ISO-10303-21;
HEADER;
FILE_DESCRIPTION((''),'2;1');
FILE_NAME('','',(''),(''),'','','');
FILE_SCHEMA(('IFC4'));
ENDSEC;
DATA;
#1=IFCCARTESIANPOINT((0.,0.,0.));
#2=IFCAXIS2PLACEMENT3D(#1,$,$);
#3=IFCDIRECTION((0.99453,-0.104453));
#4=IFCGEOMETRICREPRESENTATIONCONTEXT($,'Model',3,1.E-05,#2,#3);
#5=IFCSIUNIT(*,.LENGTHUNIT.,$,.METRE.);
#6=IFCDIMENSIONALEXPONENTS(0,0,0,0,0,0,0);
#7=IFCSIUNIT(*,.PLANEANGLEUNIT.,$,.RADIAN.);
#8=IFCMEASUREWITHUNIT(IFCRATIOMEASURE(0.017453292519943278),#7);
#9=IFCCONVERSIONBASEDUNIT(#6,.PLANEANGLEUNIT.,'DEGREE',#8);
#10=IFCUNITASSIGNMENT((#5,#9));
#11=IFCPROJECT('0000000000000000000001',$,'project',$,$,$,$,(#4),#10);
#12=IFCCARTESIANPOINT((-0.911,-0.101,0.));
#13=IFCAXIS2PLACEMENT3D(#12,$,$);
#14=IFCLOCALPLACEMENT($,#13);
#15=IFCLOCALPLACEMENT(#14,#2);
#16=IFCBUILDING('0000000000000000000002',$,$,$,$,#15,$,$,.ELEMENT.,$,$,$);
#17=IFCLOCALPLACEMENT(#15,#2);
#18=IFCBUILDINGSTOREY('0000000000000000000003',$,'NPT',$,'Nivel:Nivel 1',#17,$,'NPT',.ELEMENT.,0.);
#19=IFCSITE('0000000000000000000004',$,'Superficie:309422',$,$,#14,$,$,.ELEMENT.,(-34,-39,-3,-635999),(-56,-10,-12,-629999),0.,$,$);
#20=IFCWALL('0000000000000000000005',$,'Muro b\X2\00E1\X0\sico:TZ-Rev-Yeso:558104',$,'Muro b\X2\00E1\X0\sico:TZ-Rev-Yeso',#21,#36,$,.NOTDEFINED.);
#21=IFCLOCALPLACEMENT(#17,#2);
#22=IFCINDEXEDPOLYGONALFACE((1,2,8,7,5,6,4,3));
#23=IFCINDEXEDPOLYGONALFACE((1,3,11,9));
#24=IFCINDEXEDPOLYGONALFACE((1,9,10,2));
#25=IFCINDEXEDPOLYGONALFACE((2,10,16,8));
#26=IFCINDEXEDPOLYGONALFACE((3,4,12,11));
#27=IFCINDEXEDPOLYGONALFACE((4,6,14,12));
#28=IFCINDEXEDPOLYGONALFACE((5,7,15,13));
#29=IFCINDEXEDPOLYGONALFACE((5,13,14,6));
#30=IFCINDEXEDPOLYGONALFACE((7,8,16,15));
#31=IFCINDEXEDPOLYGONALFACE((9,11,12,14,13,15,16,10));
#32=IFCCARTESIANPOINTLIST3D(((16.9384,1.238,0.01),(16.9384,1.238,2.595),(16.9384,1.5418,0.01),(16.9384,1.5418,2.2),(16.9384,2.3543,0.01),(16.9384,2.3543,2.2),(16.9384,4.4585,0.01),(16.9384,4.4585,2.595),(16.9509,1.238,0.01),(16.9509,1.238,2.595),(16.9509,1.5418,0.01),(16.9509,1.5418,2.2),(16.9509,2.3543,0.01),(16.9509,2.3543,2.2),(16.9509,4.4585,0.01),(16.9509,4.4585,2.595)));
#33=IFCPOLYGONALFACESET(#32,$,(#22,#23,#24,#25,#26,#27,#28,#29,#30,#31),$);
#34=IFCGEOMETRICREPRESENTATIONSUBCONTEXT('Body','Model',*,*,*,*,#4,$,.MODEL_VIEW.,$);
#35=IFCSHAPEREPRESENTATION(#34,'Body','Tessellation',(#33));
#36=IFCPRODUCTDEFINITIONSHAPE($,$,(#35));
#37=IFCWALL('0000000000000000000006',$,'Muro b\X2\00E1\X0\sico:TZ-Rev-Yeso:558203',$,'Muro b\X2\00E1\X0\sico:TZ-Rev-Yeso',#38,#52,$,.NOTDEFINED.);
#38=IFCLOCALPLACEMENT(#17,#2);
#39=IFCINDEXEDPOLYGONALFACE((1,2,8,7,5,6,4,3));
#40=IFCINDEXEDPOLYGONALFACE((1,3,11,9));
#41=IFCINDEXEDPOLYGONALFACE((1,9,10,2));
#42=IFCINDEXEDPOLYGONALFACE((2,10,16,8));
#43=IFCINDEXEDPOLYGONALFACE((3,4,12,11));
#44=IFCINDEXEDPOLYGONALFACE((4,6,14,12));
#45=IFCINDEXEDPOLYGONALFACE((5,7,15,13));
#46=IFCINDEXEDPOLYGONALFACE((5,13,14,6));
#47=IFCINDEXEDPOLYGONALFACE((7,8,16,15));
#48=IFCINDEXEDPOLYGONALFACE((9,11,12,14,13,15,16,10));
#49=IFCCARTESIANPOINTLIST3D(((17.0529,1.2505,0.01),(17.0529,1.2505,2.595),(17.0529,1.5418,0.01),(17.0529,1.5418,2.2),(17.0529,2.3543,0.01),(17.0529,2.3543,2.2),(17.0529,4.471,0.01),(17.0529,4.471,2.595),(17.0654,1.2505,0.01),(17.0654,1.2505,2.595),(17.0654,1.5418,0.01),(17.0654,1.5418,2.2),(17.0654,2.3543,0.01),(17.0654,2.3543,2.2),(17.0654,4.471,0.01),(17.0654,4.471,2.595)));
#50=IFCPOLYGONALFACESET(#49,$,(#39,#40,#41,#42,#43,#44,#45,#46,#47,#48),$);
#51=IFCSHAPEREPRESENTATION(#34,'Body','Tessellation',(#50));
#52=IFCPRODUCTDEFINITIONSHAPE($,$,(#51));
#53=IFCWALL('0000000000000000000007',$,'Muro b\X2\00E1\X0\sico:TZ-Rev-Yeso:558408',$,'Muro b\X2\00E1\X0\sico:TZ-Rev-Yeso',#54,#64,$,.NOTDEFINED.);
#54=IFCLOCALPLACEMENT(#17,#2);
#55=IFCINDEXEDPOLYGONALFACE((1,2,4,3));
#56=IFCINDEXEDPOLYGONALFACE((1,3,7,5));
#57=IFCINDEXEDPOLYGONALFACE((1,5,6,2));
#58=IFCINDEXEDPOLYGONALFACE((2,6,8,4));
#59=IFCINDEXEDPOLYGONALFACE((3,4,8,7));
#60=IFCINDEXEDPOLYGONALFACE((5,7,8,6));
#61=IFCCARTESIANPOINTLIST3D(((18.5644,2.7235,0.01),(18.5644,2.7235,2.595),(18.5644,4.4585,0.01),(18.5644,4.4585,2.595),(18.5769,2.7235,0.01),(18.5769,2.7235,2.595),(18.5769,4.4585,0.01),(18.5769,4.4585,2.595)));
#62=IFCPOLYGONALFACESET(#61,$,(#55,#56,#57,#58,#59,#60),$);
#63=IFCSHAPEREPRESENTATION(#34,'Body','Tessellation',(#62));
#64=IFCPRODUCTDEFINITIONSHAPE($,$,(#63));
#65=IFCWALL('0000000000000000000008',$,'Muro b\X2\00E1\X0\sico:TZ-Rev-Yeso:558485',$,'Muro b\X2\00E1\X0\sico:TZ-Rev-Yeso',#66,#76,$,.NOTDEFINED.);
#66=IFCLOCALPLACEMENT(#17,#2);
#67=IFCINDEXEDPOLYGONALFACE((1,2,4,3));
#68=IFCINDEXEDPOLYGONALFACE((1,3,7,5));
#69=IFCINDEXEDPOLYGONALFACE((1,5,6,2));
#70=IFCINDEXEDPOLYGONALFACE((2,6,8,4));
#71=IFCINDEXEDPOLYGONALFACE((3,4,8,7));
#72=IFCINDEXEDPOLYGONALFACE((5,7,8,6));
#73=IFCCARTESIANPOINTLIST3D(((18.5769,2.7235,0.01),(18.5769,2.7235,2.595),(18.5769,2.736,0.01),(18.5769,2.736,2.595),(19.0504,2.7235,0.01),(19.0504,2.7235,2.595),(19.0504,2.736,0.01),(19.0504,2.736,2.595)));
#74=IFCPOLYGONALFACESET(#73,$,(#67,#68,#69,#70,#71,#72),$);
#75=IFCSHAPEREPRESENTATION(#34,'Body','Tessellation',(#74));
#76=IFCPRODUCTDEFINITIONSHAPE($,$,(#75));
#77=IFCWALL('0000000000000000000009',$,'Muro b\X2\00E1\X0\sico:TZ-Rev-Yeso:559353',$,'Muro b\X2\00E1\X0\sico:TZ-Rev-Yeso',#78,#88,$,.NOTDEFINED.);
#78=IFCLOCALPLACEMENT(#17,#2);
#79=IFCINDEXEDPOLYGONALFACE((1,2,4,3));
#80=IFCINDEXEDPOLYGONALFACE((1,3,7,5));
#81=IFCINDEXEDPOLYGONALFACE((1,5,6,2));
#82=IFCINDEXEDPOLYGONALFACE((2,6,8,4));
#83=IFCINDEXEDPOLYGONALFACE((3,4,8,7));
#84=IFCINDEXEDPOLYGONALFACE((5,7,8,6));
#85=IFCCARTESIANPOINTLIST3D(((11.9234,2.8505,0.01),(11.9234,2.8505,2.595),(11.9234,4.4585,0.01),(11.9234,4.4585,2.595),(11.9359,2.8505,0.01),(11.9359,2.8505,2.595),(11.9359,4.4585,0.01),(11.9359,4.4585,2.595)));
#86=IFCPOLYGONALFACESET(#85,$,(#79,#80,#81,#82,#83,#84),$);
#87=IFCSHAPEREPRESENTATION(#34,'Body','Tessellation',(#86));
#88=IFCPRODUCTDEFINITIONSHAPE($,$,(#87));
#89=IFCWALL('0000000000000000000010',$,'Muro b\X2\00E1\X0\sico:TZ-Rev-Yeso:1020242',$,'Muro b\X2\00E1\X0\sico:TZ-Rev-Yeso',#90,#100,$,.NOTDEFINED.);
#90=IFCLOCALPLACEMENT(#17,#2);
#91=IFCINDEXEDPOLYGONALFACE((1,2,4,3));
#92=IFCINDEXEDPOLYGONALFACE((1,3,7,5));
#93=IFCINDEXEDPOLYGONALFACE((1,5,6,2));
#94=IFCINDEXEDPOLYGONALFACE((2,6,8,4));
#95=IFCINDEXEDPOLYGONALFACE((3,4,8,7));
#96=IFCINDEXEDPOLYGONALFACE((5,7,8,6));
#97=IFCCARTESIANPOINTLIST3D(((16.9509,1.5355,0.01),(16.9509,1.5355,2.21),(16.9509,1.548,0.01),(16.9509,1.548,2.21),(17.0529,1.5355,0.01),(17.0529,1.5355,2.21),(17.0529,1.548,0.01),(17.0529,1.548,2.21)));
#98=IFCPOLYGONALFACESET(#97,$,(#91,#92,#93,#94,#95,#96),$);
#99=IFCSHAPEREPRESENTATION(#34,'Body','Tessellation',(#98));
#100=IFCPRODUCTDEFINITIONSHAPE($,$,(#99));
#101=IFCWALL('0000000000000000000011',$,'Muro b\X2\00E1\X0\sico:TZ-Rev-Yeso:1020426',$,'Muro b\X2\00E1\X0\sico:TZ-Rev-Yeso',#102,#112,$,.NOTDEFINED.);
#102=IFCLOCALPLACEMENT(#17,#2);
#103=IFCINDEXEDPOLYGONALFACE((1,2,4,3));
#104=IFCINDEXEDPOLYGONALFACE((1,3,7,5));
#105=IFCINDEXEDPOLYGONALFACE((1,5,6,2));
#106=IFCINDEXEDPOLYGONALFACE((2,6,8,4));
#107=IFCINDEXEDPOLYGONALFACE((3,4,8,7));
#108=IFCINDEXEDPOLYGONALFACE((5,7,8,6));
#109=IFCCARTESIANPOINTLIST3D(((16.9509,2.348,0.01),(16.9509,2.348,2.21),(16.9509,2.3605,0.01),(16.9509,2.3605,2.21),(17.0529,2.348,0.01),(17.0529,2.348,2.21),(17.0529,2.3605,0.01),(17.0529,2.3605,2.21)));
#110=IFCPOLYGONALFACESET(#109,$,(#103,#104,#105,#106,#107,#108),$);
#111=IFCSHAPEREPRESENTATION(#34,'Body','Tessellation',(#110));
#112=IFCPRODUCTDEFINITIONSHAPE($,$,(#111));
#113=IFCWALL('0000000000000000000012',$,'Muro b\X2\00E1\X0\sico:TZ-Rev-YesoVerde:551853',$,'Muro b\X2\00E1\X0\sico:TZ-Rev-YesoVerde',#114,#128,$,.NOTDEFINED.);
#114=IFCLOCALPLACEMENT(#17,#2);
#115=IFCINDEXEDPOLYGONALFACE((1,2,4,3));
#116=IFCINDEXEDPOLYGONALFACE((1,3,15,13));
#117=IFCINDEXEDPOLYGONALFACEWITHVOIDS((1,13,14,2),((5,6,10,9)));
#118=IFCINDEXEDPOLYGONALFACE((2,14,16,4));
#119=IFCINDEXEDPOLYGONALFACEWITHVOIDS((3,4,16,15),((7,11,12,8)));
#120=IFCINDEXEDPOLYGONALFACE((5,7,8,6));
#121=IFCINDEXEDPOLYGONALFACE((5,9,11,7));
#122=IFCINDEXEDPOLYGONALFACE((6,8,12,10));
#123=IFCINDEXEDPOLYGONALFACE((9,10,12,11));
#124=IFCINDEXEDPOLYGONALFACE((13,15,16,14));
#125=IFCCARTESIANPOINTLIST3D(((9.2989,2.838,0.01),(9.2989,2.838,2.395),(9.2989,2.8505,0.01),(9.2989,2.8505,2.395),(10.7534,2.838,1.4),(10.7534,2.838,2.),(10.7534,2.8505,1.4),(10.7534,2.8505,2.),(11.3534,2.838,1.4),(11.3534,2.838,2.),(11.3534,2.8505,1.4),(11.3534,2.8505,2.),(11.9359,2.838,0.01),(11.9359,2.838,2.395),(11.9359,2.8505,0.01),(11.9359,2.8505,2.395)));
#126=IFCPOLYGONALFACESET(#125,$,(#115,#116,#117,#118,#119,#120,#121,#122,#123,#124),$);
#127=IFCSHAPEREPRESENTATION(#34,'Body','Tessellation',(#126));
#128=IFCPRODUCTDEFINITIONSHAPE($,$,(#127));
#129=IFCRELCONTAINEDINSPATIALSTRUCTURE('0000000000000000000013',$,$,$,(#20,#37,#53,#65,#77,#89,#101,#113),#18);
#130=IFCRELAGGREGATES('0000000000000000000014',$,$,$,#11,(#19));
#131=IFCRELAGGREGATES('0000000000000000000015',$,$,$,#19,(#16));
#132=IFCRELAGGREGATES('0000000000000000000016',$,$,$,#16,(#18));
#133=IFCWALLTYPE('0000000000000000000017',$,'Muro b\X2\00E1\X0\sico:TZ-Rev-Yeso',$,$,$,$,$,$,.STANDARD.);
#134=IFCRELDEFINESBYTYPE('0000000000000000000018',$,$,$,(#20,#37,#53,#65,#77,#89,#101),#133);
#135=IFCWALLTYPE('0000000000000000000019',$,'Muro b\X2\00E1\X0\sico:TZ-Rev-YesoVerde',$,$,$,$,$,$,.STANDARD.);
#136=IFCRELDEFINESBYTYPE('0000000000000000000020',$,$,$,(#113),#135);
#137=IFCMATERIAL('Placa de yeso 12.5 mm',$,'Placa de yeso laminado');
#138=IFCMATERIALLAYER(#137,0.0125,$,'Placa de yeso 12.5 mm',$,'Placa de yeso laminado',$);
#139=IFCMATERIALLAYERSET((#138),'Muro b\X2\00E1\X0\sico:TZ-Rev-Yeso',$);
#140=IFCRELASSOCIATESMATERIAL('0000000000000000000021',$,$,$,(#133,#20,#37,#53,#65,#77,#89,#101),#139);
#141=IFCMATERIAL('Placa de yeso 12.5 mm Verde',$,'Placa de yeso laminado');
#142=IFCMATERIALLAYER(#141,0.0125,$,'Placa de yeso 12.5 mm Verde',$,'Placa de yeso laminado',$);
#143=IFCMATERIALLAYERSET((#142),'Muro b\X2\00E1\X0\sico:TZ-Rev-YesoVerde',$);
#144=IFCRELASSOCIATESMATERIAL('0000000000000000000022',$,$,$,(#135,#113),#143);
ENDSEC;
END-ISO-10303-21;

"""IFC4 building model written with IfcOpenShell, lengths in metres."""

from ifc_helpers import new_model, entity, si_unit, converted_unit, direction, frame, frame_2d, origin, place, context, subcontext, project, spatial, rectangle, extrude, material, layer, layer_set, layer_usage, type_object, element, save


model = new_model("IFC4")

# Units and contexts
model_context = context("Model", 3, precision=1e-05, world=origin(), true_north=direction((0.99453, -0.104453)))
body_context = subcontext(model_context, "Body", "Model", "MODEL_VIEW")
ifc_project = project(units=[si_unit("LENGTHUNIT", "METRE"), converted_unit("PLANEANGLEUNIT", "DEGREE", entity("IfcRatioMeasure", 0.017453292519943278), si_unit("PLANEANGLEUNIT", "RADIAN"), dimensions=[0, 0, 0, 0, 0, 0, 0])], contexts=[model_context])

# Site, building, storey
site_placement = place(None, frame((-0.911, -0.101, 0.0)))
site = spatial("IfcSite", under=ifc_project, at=site_placement, Name="Superficie:309422", CompositionType="ELEMENT", RefLatitude=(-34, -39, -3, -635999), RefLongitude=(-56, -10, -12, -629999), RefElevation=0.0)
building_placement = place(site_placement, origin())
building = spatial("IfcBuilding", under=site, at=building_placement, CompositionType="ELEMENT")
storey_placement = place(building_placement, origin())
storey = spatial("IfcBuildingStorey", under=building, at=storey_placement, Name="NPT", ObjectType="Nivel:Nivel 1", LongName="NPT", CompositionType="ELEMENT", Elevation=0.0)

# Shared definitions
ifc_material_1 = material(Name="Placa de yeso 12.5 mm", Category="Placa de yeso laminado")
ifc_layer_1 = layer(ifc_material_1, 0.0125, Name="Placa de yeso 12.5 mm", Category="Placa de yeso laminado")
ifc_layer_set_1 = layer_set([ifc_layer_1], Name="Muro básico:TZ-Rev-Yeso")
wall_type_1 = type_object("IfcWallType", Name="Muro básico:TZ-Rev-Yeso", PredefinedType="STANDARD", material=ifc_layer_set_1)

# Walls, openings
ifc_layer_usage_1 = layer_usage(ifc_layer_set_1, "AXIS2", "NEGATIVE", 0.0063)
wall_1_placement = place(storey_placement, frame((16.9447, 4.4585, 0.01), z_axis=(0.0, 0.0, 1.0), x_axis=(0.0, -1.0, 0.0)))
wall_1 = element("IfcWall", 1, at=wall_1_placement, inside=storey, type_object=wall_type_1, material=ifc_layer_usage_1, Name="Muro básico:TZ-Rev-Yeso:558104", ObjectType="Muro básico:TZ-Rev-Yeso", PredefinedType="NOTDEFINED", context=body_context, shape_type="SweptSolid", body=[
    extrude(rectangle(XDim=3.2205, YDim=0.0125, at=frame_2d((1.6102, 0.0), x_axis=(-1.0, 0.0))), origin(), (0.0, 0.0, 1.0), 2.585),
])
opening_1_placement = place(wall_1_placement, origin())
element("IfcOpeningElement", 2, at=opening_1_placement, cuts=wall_1, PredefinedType="OPENING", context=body_context, shape_type="SweptSolid", body=[
    extrude(rectangle(XDim=2.19, YDim=0.8125, at=frame_2d((0.0, 0.0), x_axis=(1.0, 0.0))), frame((2.5105, 0.0063, 1.095), z_axis=(0.0, -1.0, 0.0), x_axis=(0.0, 0.0, 1.0)), (0.0, 0.0, 1.0), 0.0125),
])
ifc_layer_usage_2 = layer_usage(ifc_layer_set_1, "AXIS2", "NEGATIVE", 0.0063)
wall_2_placement = place(storey_placement, frame((17.0592, 1.2505, 0.01), z_axis=(0.0, 0.0, 1.0), x_axis=(0.0, 1.0, 0.0)))
wall_2 = element("IfcWall", 3, at=wall_2_placement, inside=storey, type_object=wall_type_1, material=ifc_layer_usage_2, Name="Muro básico:TZ-Rev-Yeso:558203", ObjectType="Muro básico:TZ-Rev-Yeso", PredefinedType="NOTDEFINED", context=body_context, shape_type="SweptSolid", body=[
    extrude(rectangle(XDim=3.2205, YDim=0.0125, at=frame_2d((1.6102, 0.0), x_axis=(-1.0, 0.0))), origin(), (0.0, 0.0, 1.0), 2.585),
])
opening_2_placement = place(wall_2_placement, origin())
element("IfcOpeningElement", 4, at=opening_2_placement, cuts=wall_2, PredefinedType="OPENING", context=body_context, shape_type="SweptSolid", body=[
    extrude(rectangle(XDim=2.19, YDim=0.8125, at=frame_2d((0.0, 0.0), x_axis=(0.0, 1.0))), frame((0.6975, 0.0063, 1.095), z_axis=(0.0, -1.0, 0.0), x_axis=(1.0, 0.0, 0.0)), (0.0, 0.0, 1.0), 0.0125),
])

# Walls
ifc_layer_usage_3 = layer_usage(ifc_layer_set_1, "AXIS2", "NEGATIVE", 0.0063)
wall_3_placement = place(storey_placement, frame((18.5707, 4.4585, 0.01), z_axis=(0.0, 0.0, 1.0), x_axis=(0.0, -1.0, 0.0)))
element("IfcWall", 5, at=wall_3_placement, inside=storey, type_object=wall_type_1, material=ifc_layer_usage_3, Name="Muro básico:TZ-Rev-Yeso:558408", ObjectType="Muro básico:TZ-Rev-Yeso", PredefinedType="NOTDEFINED", context=body_context, shape_type="SweptSolid", body=[
    extrude(rectangle(XDim=1.735, YDim=0.0125, at=frame_2d((0.8675, 0.0), x_axis=(-1.0, 0.0))), origin(), (0.0, 0.0, 1.0), 2.585),
])
ifc_layer_usage_4 = layer_usage(ifc_layer_set_1, "AXIS2", "NEGATIVE", 0.0063)
wall_4_placement = place(storey_placement, frame((18.5769, 2.7298, 0.01)))
element("IfcWall", 6, at=wall_4_placement, inside=storey, type_object=wall_type_1, material=ifc_layer_usage_4, Name="Muro básico:TZ-Rev-Yeso:558485", ObjectType="Muro básico:TZ-Rev-Yeso", PredefinedType="NOTDEFINED", context=body_context, shape_type="SweptSolid", body=[
    extrude(rectangle(XDim=0.4735, YDim=0.0125, at=frame_2d((0.2368, 0.0), x_axis=(-1.0, 0.0))), origin(), (0.0, 0.0, 1.0), 2.585),
])
ifc_layer_usage_5 = layer_usage(ifc_layer_set_1, "AXIS2", "NEGATIVE", 0.0063)
wall_5_placement = place(storey_placement, frame((11.9297, 4.4585, 0.01), z_axis=(0.0, 0.0, 1.0), x_axis=(0.0, -1.0, 0.0)))
element("IfcWall", 7, at=wall_5_placement, inside=storey, type_object=wall_type_1, material=ifc_layer_usage_5, Name="Muro básico:TZ-Rev-Yeso:559353", ObjectType="Muro básico:TZ-Rev-Yeso", PredefinedType="NOTDEFINED", context=body_context, shape_type="SweptSolid", body=[
    extrude(rectangle(XDim=1.608, YDim=0.0125, at=frame_2d((0.804, 0.0), x_axis=(-1.0, 0.0))), origin(), (0.0, 0.0, 1.0), 2.585),
])
ifc_layer_usage_6 = layer_usage(ifc_layer_set_1, "AXIS2", "POSITIVE", -0.0063)
wall_6_placement = place(storey_placement, frame((16.9509, 1.5418, 0.01)))
element("IfcWall", 8, at=wall_6_placement, inside=storey, type_object=wall_type_1, material=ifc_layer_usage_6, Name="Muro básico:TZ-Rev-Yeso:1020242", ObjectType="Muro básico:TZ-Rev-Yeso", PredefinedType="NOTDEFINED", context=body_context, shape_type="SweptSolid", body=[
    extrude(rectangle(XDim=0.102, YDim=0.0125, at=frame_2d((0.051, 0.0), x_axis=(-1.0, 0.0))), origin(), (0.0, 0.0, 1.0), 2.2),
])
ifc_layer_usage_7 = layer_usage(ifc_layer_set_1, "AXIS2", "POSITIVE", -0.0063)
wall_7_placement = place(storey_placement, frame((16.9509, 2.3543, 0.01)))
element("IfcWall", 9, at=wall_7_placement, inside=storey, type_object=wall_type_1, material=ifc_layer_usage_7, Name="Muro básico:TZ-Rev-Yeso:1020426", ObjectType="Muro básico:TZ-Rev-Yeso", PredefinedType="NOTDEFINED", context=body_context, shape_type="SweptSolid", body=[
    extrude(rectangle(XDim=0.102, YDim=0.0125, at=frame_2d((0.051, 0.0), x_axis=(-1.0, 0.0))), origin(), (0.0, 0.0, 1.0), 2.2),
])

# Wall, opening
ifc_material_2 = material(Name="Placa de yeso 12.5 mm Verde", Category="Placa de yeso laminado")
ifc_layer_2 = layer(ifc_material_2, 0.0125, Name="Placa de yeso 12.5 mm Verde", Category="Placa de yeso laminado")
ifc_layer_set_2 = layer_set([ifc_layer_2], Name="Muro básico:TZ-Rev-YesoVerde")
ifc_layer_usage_8 = layer_usage(ifc_layer_set_2, "AXIS2", "NEGATIVE", 0.0063)
wall_type_2 = type_object("IfcWallType", Name="Muro básico:TZ-Rev-YesoVerde", PredefinedType="STANDARD", material=ifc_layer_set_2)
wall_8_placement = place(storey_placement, frame((11.9359, 2.8443, 0.01), z_axis=(0.0, 0.0, 1.0), x_axis=(-1.0, 0.0, 0.0)))
wall_8 = element("IfcWall", 10, at=wall_8_placement, inside=storey, type_object=wall_type_2, material=ifc_layer_usage_8, Name="Muro básico:TZ-Rev-YesoVerde:551853", ObjectType="Muro básico:TZ-Rev-YesoVerde", PredefinedType="NOTDEFINED", context=body_context, shape_type="SweptSolid", body=[
    extrude(rectangle(XDim=2.637, YDim=0.0125, at=frame_2d((1.3185, 0.0), x_axis=(-1.0, 0.0))), origin(), (0.0, 0.0, 1.0), 2.385),
])
opening_3_placement = place(wall_8_placement, frame((1.1825, 1.5303, 1.39)))
element("IfcOpeningElement", 11, at=opening_3_placement, cuts=wall_8, PredefinedType="OPENING", context=body_context, shape_type="SweptSolid", body=[
    extrude(rectangle(XDim=0.6, YDim=0.6, at=frame_2d((0.0, 0.0), x_axis=(0.0, 1.0))), frame((-0.3, -3.048, 0.3), z_axis=(0.0, 1.0, 0.0), x_axis=(-1.0, 0.0, 0.0)), (0.0, 0.0, 1.0), 3.048),
])

save(model, "model.ifc")
